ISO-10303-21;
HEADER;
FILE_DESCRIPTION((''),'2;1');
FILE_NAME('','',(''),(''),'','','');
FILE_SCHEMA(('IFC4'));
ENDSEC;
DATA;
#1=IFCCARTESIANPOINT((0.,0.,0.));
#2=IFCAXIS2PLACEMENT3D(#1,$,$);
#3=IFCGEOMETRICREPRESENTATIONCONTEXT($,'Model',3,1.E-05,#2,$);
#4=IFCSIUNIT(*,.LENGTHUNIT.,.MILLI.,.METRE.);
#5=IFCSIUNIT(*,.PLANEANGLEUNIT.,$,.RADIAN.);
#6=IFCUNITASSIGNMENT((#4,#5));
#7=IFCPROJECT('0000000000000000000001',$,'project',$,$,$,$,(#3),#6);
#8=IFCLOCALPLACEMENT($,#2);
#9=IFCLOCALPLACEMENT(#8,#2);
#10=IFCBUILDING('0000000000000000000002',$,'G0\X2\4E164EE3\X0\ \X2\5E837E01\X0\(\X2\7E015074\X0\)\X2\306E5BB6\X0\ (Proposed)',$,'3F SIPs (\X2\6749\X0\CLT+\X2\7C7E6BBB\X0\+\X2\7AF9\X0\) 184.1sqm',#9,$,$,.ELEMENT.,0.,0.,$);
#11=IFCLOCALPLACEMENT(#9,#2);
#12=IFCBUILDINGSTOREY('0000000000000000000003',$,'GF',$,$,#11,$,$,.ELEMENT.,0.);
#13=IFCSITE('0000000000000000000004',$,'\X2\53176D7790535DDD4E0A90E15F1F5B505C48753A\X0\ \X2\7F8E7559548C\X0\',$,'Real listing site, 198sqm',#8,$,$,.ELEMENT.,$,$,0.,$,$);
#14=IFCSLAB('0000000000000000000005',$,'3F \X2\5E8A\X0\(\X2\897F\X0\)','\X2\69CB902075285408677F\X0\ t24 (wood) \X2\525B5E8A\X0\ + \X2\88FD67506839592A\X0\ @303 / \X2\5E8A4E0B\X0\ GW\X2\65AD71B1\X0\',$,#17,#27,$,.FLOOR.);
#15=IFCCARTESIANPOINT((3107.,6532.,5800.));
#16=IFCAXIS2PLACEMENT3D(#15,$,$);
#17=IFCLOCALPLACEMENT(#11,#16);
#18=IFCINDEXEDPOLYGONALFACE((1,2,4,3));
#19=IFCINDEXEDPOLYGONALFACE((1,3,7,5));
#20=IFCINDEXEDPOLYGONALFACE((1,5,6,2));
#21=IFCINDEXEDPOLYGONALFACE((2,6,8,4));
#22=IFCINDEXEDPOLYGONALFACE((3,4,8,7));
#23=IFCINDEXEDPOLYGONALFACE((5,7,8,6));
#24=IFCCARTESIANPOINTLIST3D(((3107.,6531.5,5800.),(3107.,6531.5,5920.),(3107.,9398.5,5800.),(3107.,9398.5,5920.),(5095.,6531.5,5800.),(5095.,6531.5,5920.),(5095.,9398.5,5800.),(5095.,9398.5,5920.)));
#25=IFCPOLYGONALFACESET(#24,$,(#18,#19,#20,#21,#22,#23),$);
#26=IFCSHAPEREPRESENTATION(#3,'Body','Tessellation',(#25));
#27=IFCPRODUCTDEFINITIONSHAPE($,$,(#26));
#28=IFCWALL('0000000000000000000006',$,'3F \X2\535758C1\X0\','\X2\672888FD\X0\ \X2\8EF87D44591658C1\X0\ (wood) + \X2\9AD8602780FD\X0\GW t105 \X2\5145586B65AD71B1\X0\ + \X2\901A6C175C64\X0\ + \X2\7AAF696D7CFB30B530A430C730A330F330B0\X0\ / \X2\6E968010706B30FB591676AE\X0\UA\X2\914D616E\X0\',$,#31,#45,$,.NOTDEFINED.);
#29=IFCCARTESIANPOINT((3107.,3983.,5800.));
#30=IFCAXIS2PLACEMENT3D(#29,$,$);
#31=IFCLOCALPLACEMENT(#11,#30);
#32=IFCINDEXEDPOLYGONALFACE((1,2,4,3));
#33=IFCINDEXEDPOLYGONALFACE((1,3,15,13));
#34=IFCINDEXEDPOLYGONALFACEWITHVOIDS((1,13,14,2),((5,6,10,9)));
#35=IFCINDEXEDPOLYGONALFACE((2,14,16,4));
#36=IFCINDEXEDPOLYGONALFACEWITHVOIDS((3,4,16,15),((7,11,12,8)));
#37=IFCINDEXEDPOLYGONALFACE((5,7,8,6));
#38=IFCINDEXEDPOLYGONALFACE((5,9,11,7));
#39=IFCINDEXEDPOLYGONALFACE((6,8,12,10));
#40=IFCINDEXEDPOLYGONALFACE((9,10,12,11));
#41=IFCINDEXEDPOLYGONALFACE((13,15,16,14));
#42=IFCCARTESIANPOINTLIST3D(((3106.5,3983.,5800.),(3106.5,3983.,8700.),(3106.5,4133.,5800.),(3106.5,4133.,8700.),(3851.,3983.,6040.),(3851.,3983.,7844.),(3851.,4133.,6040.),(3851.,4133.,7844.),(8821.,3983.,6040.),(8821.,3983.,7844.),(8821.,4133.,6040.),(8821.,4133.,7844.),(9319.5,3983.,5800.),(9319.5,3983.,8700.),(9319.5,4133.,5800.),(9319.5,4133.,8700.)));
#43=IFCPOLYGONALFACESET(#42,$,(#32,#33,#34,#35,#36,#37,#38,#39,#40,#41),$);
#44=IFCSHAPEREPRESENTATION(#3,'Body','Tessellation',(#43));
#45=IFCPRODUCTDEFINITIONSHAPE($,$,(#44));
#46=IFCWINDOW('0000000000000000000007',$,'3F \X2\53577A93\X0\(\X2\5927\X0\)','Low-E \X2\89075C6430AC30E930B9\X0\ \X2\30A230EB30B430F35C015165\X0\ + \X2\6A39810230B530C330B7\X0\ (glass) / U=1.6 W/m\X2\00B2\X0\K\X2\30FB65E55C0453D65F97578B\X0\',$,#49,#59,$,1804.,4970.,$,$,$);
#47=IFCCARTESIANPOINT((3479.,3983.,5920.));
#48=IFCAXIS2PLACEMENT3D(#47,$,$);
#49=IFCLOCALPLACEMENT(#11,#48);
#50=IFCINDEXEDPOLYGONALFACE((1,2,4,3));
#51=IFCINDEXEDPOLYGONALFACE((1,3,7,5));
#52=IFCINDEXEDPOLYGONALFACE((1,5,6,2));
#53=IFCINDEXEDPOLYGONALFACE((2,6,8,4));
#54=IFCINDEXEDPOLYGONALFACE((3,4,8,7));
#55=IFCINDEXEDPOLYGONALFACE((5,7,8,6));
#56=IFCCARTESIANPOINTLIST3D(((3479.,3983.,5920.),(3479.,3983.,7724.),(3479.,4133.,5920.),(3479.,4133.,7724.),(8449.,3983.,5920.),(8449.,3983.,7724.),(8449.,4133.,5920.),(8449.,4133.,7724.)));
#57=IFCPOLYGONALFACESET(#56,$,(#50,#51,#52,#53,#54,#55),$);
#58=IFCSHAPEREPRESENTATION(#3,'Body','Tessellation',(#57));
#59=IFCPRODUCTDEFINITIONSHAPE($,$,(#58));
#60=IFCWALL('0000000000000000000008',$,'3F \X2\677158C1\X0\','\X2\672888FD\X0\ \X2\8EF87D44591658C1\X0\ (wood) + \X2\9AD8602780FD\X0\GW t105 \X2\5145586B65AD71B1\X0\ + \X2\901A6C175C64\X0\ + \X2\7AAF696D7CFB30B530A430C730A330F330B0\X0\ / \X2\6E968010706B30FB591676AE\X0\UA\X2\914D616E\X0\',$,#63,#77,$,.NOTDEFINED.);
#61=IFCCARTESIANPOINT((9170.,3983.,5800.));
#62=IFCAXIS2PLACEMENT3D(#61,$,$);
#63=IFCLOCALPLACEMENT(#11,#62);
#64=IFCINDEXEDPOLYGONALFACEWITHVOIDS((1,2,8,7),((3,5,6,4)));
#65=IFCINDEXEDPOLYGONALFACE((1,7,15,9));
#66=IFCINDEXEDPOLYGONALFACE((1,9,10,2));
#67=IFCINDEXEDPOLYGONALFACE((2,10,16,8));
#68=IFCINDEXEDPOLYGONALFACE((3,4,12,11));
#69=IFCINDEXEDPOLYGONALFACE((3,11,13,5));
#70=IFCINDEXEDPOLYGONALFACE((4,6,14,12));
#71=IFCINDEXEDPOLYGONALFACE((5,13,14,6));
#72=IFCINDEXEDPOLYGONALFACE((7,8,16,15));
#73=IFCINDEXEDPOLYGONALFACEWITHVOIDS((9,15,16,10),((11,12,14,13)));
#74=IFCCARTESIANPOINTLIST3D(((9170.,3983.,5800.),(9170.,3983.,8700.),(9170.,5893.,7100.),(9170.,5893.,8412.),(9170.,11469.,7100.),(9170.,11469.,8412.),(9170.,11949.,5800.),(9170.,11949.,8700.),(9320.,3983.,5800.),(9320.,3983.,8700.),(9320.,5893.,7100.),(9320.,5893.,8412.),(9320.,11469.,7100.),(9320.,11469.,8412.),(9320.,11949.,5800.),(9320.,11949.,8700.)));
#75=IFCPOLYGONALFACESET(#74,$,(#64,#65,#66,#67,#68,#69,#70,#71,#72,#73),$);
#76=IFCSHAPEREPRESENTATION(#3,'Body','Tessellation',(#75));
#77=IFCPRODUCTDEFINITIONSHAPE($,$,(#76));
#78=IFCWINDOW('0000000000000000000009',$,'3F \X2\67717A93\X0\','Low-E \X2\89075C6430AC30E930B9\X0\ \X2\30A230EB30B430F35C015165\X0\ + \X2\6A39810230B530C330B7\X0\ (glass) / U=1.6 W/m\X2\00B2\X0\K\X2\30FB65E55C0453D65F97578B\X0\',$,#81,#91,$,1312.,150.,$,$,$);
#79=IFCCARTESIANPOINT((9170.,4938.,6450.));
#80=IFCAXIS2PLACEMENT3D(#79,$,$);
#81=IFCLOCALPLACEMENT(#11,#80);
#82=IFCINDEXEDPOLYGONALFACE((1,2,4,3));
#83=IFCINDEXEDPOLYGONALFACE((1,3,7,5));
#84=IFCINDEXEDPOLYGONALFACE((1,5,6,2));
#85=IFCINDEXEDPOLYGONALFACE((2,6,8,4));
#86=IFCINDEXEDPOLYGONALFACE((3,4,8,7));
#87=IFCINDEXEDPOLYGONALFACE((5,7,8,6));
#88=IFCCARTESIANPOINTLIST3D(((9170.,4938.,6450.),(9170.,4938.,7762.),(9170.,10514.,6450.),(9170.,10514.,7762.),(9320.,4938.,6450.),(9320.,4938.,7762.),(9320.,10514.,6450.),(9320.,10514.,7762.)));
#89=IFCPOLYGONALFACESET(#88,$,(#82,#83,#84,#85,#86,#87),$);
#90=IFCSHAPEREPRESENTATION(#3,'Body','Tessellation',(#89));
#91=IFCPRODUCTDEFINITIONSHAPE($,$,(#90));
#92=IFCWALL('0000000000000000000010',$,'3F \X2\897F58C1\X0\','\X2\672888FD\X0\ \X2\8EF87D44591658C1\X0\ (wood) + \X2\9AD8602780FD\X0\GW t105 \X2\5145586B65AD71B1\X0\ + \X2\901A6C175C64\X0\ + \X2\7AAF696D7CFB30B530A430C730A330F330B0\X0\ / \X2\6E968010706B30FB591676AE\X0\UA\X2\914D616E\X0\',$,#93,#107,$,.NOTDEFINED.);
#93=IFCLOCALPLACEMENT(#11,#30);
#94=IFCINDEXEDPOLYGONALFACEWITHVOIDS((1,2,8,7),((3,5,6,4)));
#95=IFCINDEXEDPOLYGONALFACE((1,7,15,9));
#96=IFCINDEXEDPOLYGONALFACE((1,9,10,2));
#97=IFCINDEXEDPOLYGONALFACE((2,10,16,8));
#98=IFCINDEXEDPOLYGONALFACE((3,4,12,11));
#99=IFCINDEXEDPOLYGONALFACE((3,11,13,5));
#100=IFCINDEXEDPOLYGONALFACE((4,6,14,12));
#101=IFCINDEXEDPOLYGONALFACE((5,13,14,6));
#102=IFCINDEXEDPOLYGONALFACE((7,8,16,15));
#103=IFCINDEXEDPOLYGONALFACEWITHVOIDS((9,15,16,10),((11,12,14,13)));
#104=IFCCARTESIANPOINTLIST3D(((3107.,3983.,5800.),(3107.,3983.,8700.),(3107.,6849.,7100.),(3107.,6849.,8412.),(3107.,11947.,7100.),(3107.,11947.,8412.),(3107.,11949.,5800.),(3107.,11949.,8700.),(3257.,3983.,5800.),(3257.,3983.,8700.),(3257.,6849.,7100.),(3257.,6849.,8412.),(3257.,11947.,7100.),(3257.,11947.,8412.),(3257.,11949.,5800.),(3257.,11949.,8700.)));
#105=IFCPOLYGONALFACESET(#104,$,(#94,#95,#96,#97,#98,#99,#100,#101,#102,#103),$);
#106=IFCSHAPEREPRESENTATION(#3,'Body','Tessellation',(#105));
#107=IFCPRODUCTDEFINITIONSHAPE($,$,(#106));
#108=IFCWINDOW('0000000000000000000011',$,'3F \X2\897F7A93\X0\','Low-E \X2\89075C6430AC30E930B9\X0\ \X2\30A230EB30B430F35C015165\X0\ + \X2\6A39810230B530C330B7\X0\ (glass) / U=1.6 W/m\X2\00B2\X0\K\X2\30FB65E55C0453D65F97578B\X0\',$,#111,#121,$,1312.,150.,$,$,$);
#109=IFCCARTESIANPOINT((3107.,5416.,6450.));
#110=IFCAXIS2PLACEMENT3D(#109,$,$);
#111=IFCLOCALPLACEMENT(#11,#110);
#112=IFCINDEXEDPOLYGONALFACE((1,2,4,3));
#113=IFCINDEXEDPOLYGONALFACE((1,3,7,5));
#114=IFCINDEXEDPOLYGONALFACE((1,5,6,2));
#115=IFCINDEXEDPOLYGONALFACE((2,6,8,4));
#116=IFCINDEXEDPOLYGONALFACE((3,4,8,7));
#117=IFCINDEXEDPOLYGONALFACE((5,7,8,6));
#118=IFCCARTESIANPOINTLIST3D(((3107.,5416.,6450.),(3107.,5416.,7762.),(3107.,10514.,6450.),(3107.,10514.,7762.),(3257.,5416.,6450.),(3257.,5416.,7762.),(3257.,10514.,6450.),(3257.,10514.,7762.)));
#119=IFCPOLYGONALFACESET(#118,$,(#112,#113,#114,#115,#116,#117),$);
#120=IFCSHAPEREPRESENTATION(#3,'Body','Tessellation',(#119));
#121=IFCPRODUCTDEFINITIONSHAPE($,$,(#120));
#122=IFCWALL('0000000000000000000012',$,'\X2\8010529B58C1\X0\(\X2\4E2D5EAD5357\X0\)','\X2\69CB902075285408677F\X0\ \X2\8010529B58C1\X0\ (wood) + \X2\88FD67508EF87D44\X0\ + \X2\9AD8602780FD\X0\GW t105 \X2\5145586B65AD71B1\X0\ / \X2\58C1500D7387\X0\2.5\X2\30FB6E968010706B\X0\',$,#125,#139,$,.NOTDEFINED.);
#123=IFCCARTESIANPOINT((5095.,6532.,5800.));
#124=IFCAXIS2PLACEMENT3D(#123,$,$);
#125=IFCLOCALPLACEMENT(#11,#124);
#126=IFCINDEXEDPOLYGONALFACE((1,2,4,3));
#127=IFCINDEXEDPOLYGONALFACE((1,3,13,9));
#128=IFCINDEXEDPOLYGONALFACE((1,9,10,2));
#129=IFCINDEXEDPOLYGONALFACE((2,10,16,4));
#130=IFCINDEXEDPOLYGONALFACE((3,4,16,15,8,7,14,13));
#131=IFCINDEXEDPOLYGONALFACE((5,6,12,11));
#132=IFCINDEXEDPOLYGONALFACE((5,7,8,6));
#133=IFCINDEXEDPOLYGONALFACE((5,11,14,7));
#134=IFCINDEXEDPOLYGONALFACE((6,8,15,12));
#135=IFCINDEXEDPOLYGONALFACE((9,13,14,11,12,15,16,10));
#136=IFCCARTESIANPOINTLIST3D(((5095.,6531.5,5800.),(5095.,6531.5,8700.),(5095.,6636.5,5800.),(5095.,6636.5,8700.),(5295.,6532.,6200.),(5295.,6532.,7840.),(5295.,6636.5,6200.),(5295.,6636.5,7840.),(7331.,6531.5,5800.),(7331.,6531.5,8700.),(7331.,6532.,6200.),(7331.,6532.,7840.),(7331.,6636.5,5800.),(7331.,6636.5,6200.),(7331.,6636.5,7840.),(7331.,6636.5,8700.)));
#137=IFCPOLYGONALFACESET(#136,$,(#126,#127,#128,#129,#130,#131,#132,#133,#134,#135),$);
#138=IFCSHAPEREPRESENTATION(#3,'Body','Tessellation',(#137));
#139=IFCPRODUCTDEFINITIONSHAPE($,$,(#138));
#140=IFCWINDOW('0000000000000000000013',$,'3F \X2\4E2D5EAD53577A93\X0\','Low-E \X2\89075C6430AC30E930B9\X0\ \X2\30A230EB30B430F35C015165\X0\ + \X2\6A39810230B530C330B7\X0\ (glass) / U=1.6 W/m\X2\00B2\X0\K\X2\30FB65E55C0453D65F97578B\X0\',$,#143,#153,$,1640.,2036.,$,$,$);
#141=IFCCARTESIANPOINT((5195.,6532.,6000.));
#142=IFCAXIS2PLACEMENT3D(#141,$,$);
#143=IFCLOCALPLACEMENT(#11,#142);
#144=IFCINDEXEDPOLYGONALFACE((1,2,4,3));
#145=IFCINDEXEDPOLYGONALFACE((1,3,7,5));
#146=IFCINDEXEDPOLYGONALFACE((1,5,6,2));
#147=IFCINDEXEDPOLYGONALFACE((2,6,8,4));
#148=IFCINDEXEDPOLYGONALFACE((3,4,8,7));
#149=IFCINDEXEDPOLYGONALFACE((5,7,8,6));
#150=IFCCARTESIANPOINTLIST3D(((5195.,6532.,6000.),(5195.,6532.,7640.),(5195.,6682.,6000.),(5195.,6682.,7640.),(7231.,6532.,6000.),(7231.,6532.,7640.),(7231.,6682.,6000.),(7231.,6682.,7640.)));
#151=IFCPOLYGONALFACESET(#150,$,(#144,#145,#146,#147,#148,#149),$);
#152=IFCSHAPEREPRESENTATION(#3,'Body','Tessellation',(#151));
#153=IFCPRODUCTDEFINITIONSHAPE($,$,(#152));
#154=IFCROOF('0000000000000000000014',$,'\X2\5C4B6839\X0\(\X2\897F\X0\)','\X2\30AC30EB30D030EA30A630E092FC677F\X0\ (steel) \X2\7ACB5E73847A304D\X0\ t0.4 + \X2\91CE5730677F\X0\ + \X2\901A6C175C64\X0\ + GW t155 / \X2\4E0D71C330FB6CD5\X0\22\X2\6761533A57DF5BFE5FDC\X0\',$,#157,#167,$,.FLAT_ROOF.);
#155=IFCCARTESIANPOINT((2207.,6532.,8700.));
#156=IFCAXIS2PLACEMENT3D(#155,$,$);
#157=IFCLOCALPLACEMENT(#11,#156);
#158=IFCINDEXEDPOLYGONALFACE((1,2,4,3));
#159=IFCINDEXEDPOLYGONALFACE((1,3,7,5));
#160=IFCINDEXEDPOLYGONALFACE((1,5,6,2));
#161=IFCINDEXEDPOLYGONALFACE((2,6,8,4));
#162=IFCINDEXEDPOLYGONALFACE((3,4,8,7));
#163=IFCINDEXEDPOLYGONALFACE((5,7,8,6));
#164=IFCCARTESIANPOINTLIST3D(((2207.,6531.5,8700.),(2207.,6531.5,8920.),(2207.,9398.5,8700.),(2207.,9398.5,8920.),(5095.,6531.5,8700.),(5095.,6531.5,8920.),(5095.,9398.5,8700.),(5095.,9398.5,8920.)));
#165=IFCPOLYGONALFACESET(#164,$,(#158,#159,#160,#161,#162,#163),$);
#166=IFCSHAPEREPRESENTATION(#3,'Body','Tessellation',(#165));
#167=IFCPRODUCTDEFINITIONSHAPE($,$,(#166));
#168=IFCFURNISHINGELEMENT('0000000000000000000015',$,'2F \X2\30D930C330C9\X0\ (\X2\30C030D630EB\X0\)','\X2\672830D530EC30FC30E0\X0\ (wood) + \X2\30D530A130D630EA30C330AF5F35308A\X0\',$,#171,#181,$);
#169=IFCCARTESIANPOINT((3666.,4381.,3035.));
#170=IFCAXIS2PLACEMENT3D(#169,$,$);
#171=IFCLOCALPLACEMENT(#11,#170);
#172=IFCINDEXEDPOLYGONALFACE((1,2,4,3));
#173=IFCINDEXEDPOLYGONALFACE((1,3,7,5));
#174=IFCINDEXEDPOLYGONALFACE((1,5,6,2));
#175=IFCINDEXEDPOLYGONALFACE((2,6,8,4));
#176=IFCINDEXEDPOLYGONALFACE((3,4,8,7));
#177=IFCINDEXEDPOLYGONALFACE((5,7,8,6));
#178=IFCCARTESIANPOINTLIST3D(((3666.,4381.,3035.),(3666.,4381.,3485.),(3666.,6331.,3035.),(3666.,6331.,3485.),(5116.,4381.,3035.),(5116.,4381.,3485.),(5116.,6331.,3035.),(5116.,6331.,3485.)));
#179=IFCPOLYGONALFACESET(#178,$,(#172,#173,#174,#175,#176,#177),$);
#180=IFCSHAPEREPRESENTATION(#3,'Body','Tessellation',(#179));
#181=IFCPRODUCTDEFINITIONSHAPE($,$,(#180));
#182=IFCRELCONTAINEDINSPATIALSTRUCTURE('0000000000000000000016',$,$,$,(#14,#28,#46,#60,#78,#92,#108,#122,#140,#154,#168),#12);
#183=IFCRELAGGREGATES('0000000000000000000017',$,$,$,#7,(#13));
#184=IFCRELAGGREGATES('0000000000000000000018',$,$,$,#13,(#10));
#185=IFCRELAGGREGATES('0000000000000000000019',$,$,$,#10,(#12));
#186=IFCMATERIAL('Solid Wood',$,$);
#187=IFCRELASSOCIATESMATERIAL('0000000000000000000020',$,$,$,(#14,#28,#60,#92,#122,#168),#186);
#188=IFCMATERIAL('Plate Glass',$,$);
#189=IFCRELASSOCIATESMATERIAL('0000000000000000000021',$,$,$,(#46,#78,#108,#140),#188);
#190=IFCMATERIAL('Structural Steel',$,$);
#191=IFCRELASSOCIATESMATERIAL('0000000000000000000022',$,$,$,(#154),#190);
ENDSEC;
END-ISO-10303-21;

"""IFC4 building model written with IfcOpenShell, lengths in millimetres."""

from ifc_helpers import new_model, si_unit, frame, frame_2d, origin, place, context, project, spatial, rectangle, extrude, material, element, fill, save


model = new_model("IFC4")

# Units and contexts
model_context = context("Model", 3, precision=1e-05, world=origin())
ifc_project = project(units=[si_unit("LENGTHUNIT", "METRE", prefix="MILLI"), si_unit("PLANEANGLEUNIT", "RADIAN")], contexts=[model_context])

# Site, building, storey
site_placement = place(None, origin())
site = spatial("IfcSite", under=ifc_project, at=site_placement, Name="北海道川上郡弟子屈町 美留和", ObjectType="Real listing site, 198sqm", CompositionType="ELEMENT", RefElevation=0.0)
building_placement = place(site_placement, origin())
building = spatial("IfcBuilding", under=site, at=building_placement, Name="G0世代 広縁(縁側)の家 (Proposed)", ObjectType="3F SIPs (杉CLT+籾殻+竹) 184.1sqm", CompositionType="ELEMENT", ElevationOfRefHeight=0.0, ElevationOfTerrain=0.0)
storey_placement = place(building_placement, origin())
storey = spatial("IfcBuildingStorey", under=building, at=storey_placement, Name="GF", CompositionType="ELEMENT", Elevation=0.0)

# Slab
ifc_material_1 = material(Name="Solid Wood")
slab_1_placement = place(storey_placement, frame((3107.0, 6532.0, 5800.0)))
element("IfcSlab", 1, at=slab_1_placement, inside=storey, material=ifc_material_1, Name="3F 床(西)", Description="構造用合板 t24 (wood) 剛床 + 製材根太 @303 / 床下 GW断熱", PredefinedType="FLOOR", context=model_context, shape_type="SweptSolid", body=[
    extrude(rectangle(XDim=1988.0, YDim=2867.0, at=frame_2d((994.0, 1433.0))), frame((3107.0, 6532.0, 5800.0)), (0.0, 0.0, 1.0), 120.0),
])

# Walls, openings, windows
wall_1_placement = place(storey_placement, frame((3107.0, 3983.0, 5800.0)))
wall_1 = element("IfcWall", 2, at=wall_1_placement, inside=storey, material=ifc_material_1, Name="3F 南壁", Description="木製 軸組外壁 (wood) + 高性能GW t105 充填断熱 + 通気層 + 窯業系サイディング / 準耐火・外皮UA配慮", PredefinedType="NOTDEFINED", context=model_context, shape_type="SweptSolid", body=[
    extrude(rectangle(XDim=6213.0, YDim=150.0, at=frame_2d((3106.0, 75.0))), frame((3107.0, 3983.0, 5800.0)), (0.0, 0.0, 1.0), 2900.0),
])
opening_1_placement = place(storey_placement, frame((3479.0, 3983.0, 5920.0)))
opening_1 = element("IfcOpeningElement", 3, at=opening_1_placement, cuts=wall_1, PredefinedType="NOTDEFINED", context=model_context, shape_type="SweptSolid", body=[
    extrude(rectangle(XDim=4970.0, YDim=150.0, at=frame_2d((2485.0, 75.0))), frame((3479.0, 3983.0, 5920.0)), (0.0, 0.0, 1.0), 1804.0),
])
ifc_material_2 = material(Name="Plate Glass")
window_1_placement = place(storey_placement, frame((3479.0, 3983.0, 5920.0)))
window_1 = element("IfcWindow", 4, at=window_1_placement, inside=storey, material=ifc_material_2, Name="3F 南窓(大)", Description="Low-E 複層ガラス アルゴン封入 + 樹脂サッシ (glass) / U=1.6 W/m²K・日射取得型", OverallHeight=1804.0, OverallWidth=4970.0, context=model_context, shape_type="SweptSolid", body=[
    extrude(rectangle(XDim=4970.0, YDim=150.0, at=frame_2d((2485.0, 75.0))), frame((3479.0, 3983.0, 5920.0)), (0.0, 0.0, 1.0), 1804.0),
])
fill(opening_1, window_1)
wall_2_placement = place(storey_placement, frame((9170.0, 3983.0, 5800.0)))
wall_2 = element("IfcWall", 5, at=wall_2_placement, inside=storey, material=ifc_material_1, Name="3F 東壁", Description="木製 軸組外壁 (wood) + 高性能GW t105 充填断熱 + 通気層 + 窯業系サイディング / 準耐火・外皮UA配慮", PredefinedType="NOTDEFINED", context=model_context, shape_type="SweptSolid", body=[
    extrude(rectangle(XDim=150.0, YDim=7966.0, at=frame_2d((75.0, 3983.0))), frame((9170.0, 3983.0, 5800.0)), (0.0, 0.0, 1.0), 2900.0),
])
opening_2_placement = place(storey_placement, frame((9170.0, 4938.0, 6450.0)))
opening_2 = element("IfcOpeningElement", 6, at=opening_2_placement, cuts=wall_2, PredefinedType="NOTDEFINED", context=model_context, shape_type="SweptSolid", body=[
    extrude(rectangle(XDim=150.0, YDim=5576.0, at=frame_2d((75.0, 2788.0))), frame((9170.0, 4938.0, 6450.0)), (0.0, 0.0, 1.0), 1312.0),
])
window_2_placement = place(storey_placement, frame((9170.0, 4938.0, 6450.0)))
window_2 = element("IfcWindow", 7, at=window_2_placement, inside=storey, material=ifc_material_2, Name="3F 東窓", Description="Low-E 複層ガラス アルゴン封入 + 樹脂サッシ (glass) / U=1.6 W/m²K・日射取得型", OverallHeight=1312.0, OverallWidth=150.0, context=model_context, shape_type="SweptSolid", body=[
    extrude(rectangle(XDim=150.0, YDim=5576.0, at=frame_2d((75.0, 2788.0))), frame((9170.0, 4938.0, 6450.0)), (0.0, 0.0, 1.0), 1312.0),
])
fill(opening_2, window_2)
wall_3_placement = place(storey_placement, frame((3107.0, 3983.0, 5800.0)))
wall_3 = element("IfcWall", 8, at=wall_3_placement, inside=storey, material=ifc_material_1, Name="3F 西壁", Description="木製 軸組外壁 (wood) + 高性能GW t105 充填断熱 + 通気層 + 窯業系サイディング / 準耐火・外皮UA配慮", PredefinedType="NOTDEFINED", context=model_context, shape_type="SweptSolid", body=[
    extrude(rectangle(XDim=150.0, YDim=7966.0, at=frame_2d((75.0, 3983.0))), frame((3107.0, 3983.0, 5800.0)), (0.0, 0.0, 1.0), 2900.0),
])
opening_3_placement = place(storey_placement, frame((3107.0, 5416.0, 6450.0)))
opening_3 = element("IfcOpeningElement", 9, at=opening_3_placement, cuts=wall_3, PredefinedType="NOTDEFINED", context=model_context, shape_type="SweptSolid", body=[
    extrude(rectangle(XDim=150.0, YDim=5098.0, at=frame_2d((75.0, 2549.0))), frame((3107.0, 5416.0, 6450.0)), (0.0, 0.0, 1.0), 1312.0),
])
window_3_placement = place(storey_placement, frame((3107.0, 5416.0, 6450.0)))
window_3 = element("IfcWindow", 10, at=window_3_placement, inside=storey, material=ifc_material_2, Name="3F 西窓", Description="Low-E 複層ガラス アルゴン封入 + 樹脂サッシ (glass) / U=1.6 W/m²K・日射取得型", OverallHeight=1312.0, OverallWidth=150.0, context=model_context, shape_type="SweptSolid", body=[
    extrude(rectangle(XDim=150.0, YDim=5098.0, at=frame_2d((75.0, 2549.0))), frame((3107.0, 5416.0, 6450.0)), (0.0, 0.0, 1.0), 1312.0),
])
fill(opening_3, window_3)
wall_4_placement = place(storey_placement, frame((5095.0, 6532.0, 5800.0)))
wall_4 = element("IfcWall", 11, at=wall_4_placement, inside=storey, material=ifc_material_1, Name="耐力壁(中庭南)", Description="構造用合板 耐力壁 (wood) + 製材軸組 + 高性能GW t105 充填断熱 / 壁倍率2.5・準耐火", PredefinedType="NOTDEFINED", context=model_context, shape_type="SweptSolid", body=[
    extrude(rectangle(XDim=2236.0, YDim=105.0, at=frame_2d((1118.0, 52.0))), frame((5095.0, 6532.0, 5800.0)), (0.0, 0.0, 1.0), 2900.0),
])
opening_4_placement = place(storey_placement, frame((5195.0, 6532.0, 6000.0)))
opening_4 = element("IfcOpeningElement", 12, at=opening_4_placement, cuts=wall_4, PredefinedType="NOTDEFINED", context=model_context, shape_type="SweptSolid", body=[
    extrude(rectangle(XDim=2036.0, YDim=150.0, at=frame_2d((1018.0, 75.0))), frame((5195.0, 6532.0, 6000.0)), (0.0, 0.0, 1.0), 1640.0),
])
window_4_placement = place(storey_placement, frame((5195.0, 6532.0, 6000.0)))
window_4 = element("IfcWindow", 13, at=window_4_placement, inside=storey, material=ifc_material_2, Name="3F 中庭南窓", Description="Low-E 複層ガラス アルゴン封入 + 樹脂サッシ (glass) / U=1.6 W/m²K・日射取得型", OverallHeight=1640.0, OverallWidth=2036.0, context=model_context, shape_type="SweptSolid", body=[
    extrude(rectangle(XDim=2036.0, YDim=150.0, at=frame_2d((1018.0, 75.0))), frame((5195.0, 6532.0, 6000.0)), (0.0, 0.0, 1.0), 1640.0),
])
fill(opening_4, window_4)

# Roof
ifc_material_3 = material(Name="Structural Steel")
roof_1_placement = place(storey_placement, frame((2207.0, 6532.0, 8700.0)))
element("IfcRoof", 14, at=roof_1_placement, inside=storey, material=ifc_material_3, Name="屋根(西)", Description="ガルバリウム鋼板 (steel) 立平葺き t0.4 + 野地板 + 通気層 + GW t155 / 不燃・法22条区域対応", PredefinedType="FLAT_ROOF", context=model_context, shape_type="SweptSolid", body=[
    extrude(rectangle(XDim=2888.0, YDim=2867.0, at=frame_2d((1444.0, 1433.0))), frame((2207.0, 6532.0, 8700.0)), (0.0, 0.0, 1.0), 220.0),
])

# Furnishing element
furnishing_1_placement = place(storey_placement, frame((3666.0, 4381.0, 3035.0)))
element("IfcFurnishingElement", 15, at=furnishing_1_placement, inside=storey, material=ifc_material_1, Name="2F ベッド (ダブル)", Description="木フレーム (wood) + ファブリック張り", context=model_context, shape_type="SweptSolid", body=[
    extrude(rectangle(XDim=1450.0, YDim=1950.0, at=frame_2d((725.0, 975.0))), frame((3666.0, 4381.0, 3035.0)), (0.0, 0.0, 1.0), 450.0),
])

save(model, "model.ifc")
